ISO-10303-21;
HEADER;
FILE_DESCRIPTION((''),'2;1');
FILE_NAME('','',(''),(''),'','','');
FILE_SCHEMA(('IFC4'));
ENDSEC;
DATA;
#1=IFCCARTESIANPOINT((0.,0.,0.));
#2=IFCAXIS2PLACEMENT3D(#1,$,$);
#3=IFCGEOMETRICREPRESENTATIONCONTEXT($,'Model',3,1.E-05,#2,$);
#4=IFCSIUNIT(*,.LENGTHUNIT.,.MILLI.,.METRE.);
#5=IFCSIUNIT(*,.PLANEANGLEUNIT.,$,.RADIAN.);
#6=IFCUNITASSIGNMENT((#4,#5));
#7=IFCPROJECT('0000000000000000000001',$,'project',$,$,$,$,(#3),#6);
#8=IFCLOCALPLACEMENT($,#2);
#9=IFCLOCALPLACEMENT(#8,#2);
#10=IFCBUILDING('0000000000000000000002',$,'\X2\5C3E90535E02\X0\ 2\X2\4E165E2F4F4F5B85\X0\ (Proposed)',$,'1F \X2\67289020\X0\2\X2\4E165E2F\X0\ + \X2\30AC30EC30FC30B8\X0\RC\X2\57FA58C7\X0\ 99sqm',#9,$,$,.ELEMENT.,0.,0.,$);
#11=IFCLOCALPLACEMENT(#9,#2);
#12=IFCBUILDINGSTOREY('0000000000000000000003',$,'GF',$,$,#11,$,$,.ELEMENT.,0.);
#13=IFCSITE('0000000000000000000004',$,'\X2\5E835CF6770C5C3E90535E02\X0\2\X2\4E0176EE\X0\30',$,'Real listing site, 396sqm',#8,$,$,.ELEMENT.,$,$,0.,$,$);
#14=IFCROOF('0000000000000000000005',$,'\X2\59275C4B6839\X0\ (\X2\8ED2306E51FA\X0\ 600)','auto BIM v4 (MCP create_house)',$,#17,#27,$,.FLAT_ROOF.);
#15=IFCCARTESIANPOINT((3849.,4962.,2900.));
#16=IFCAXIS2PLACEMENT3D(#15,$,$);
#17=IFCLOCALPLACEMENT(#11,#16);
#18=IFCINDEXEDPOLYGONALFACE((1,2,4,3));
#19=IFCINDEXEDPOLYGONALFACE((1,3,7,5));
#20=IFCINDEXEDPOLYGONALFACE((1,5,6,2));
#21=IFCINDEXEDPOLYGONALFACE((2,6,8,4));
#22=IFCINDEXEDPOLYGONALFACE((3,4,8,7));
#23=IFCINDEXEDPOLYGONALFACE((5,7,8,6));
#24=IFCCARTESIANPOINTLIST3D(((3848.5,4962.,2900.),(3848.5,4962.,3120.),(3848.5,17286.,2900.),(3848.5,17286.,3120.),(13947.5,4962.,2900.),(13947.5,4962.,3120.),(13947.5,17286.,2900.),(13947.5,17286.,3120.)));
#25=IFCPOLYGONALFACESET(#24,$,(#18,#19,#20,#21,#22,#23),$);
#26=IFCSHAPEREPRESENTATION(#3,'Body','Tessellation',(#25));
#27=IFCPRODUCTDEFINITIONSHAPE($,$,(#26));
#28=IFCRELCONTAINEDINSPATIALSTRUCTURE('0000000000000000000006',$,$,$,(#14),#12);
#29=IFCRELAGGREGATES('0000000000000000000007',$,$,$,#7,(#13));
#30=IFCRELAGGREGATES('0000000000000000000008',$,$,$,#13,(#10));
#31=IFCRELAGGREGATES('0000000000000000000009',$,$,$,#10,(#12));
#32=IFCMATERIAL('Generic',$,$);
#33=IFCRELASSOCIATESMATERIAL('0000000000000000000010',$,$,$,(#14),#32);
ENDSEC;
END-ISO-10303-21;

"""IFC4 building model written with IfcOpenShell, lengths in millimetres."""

from ifc_helpers import new_model, si_unit, frame, frame_2d, origin, place, context, project, spatial, rectangle, extrude, material, element, save


model = new_model("IFC4")

# Units and contexts
model_context = context("Model", 3, precision=1e-05, world=origin())
ifc_project = project(units=[si_unit("LENGTHUNIT", "METRE", prefix="MILLI"), si_unit("PLANEANGLEUNIT", "RADIAN")], contexts=[model_context])

# Site, building, storey
site_placement = place(None, origin())
site = spatial("IfcSite", under=ifc_project, at=site_placement, Name="広島県尾道市2丁目30", ObjectType="Real listing site, 396sqm", CompositionType="ELEMENT", RefElevation=0.0)
building_placement = place(site_placement, origin())
building = spatial("IfcBuilding", under=site, at=building_placement, Name="尾道市 2世帯住宅 (Proposed)", ObjectType="1F 木造2世帯 + ガレージRC基壇 99sqm", CompositionType="ELEMENT", ElevationOfRefHeight=0.0, ElevationOfTerrain=0.0)
storey_placement = place(building_placement, origin())
storey = spatial("IfcBuildingStorey", under=building, at=storey_placement, Name="GF", CompositionType="ELEMENT", Elevation=0.0)

# Shared definitions
ifc_material = material(Name="Generic")

# Roof
roof_placement = place(storey_placement, frame((3849.0, 4962.0, 2900.0)))
element("IfcRoof", 1, at=roof_placement, inside=storey, material=ifc_material, Name="大屋根 (軒の出 600)", Description="auto BIM v4 (MCP create_house)", PredefinedType="FLAT_ROOF", context=model_context, shape_type="SweptSolid", body=[
    extrude(rectangle(XDim=10099.0, YDim=12324.0, at=frame_2d((5049.0, 6162.0))), frame((3849.0, 4962.0, 2900.0)), (0.0, 0.0, 1.0), 220.0),
])

save(model, "model.ifc")
